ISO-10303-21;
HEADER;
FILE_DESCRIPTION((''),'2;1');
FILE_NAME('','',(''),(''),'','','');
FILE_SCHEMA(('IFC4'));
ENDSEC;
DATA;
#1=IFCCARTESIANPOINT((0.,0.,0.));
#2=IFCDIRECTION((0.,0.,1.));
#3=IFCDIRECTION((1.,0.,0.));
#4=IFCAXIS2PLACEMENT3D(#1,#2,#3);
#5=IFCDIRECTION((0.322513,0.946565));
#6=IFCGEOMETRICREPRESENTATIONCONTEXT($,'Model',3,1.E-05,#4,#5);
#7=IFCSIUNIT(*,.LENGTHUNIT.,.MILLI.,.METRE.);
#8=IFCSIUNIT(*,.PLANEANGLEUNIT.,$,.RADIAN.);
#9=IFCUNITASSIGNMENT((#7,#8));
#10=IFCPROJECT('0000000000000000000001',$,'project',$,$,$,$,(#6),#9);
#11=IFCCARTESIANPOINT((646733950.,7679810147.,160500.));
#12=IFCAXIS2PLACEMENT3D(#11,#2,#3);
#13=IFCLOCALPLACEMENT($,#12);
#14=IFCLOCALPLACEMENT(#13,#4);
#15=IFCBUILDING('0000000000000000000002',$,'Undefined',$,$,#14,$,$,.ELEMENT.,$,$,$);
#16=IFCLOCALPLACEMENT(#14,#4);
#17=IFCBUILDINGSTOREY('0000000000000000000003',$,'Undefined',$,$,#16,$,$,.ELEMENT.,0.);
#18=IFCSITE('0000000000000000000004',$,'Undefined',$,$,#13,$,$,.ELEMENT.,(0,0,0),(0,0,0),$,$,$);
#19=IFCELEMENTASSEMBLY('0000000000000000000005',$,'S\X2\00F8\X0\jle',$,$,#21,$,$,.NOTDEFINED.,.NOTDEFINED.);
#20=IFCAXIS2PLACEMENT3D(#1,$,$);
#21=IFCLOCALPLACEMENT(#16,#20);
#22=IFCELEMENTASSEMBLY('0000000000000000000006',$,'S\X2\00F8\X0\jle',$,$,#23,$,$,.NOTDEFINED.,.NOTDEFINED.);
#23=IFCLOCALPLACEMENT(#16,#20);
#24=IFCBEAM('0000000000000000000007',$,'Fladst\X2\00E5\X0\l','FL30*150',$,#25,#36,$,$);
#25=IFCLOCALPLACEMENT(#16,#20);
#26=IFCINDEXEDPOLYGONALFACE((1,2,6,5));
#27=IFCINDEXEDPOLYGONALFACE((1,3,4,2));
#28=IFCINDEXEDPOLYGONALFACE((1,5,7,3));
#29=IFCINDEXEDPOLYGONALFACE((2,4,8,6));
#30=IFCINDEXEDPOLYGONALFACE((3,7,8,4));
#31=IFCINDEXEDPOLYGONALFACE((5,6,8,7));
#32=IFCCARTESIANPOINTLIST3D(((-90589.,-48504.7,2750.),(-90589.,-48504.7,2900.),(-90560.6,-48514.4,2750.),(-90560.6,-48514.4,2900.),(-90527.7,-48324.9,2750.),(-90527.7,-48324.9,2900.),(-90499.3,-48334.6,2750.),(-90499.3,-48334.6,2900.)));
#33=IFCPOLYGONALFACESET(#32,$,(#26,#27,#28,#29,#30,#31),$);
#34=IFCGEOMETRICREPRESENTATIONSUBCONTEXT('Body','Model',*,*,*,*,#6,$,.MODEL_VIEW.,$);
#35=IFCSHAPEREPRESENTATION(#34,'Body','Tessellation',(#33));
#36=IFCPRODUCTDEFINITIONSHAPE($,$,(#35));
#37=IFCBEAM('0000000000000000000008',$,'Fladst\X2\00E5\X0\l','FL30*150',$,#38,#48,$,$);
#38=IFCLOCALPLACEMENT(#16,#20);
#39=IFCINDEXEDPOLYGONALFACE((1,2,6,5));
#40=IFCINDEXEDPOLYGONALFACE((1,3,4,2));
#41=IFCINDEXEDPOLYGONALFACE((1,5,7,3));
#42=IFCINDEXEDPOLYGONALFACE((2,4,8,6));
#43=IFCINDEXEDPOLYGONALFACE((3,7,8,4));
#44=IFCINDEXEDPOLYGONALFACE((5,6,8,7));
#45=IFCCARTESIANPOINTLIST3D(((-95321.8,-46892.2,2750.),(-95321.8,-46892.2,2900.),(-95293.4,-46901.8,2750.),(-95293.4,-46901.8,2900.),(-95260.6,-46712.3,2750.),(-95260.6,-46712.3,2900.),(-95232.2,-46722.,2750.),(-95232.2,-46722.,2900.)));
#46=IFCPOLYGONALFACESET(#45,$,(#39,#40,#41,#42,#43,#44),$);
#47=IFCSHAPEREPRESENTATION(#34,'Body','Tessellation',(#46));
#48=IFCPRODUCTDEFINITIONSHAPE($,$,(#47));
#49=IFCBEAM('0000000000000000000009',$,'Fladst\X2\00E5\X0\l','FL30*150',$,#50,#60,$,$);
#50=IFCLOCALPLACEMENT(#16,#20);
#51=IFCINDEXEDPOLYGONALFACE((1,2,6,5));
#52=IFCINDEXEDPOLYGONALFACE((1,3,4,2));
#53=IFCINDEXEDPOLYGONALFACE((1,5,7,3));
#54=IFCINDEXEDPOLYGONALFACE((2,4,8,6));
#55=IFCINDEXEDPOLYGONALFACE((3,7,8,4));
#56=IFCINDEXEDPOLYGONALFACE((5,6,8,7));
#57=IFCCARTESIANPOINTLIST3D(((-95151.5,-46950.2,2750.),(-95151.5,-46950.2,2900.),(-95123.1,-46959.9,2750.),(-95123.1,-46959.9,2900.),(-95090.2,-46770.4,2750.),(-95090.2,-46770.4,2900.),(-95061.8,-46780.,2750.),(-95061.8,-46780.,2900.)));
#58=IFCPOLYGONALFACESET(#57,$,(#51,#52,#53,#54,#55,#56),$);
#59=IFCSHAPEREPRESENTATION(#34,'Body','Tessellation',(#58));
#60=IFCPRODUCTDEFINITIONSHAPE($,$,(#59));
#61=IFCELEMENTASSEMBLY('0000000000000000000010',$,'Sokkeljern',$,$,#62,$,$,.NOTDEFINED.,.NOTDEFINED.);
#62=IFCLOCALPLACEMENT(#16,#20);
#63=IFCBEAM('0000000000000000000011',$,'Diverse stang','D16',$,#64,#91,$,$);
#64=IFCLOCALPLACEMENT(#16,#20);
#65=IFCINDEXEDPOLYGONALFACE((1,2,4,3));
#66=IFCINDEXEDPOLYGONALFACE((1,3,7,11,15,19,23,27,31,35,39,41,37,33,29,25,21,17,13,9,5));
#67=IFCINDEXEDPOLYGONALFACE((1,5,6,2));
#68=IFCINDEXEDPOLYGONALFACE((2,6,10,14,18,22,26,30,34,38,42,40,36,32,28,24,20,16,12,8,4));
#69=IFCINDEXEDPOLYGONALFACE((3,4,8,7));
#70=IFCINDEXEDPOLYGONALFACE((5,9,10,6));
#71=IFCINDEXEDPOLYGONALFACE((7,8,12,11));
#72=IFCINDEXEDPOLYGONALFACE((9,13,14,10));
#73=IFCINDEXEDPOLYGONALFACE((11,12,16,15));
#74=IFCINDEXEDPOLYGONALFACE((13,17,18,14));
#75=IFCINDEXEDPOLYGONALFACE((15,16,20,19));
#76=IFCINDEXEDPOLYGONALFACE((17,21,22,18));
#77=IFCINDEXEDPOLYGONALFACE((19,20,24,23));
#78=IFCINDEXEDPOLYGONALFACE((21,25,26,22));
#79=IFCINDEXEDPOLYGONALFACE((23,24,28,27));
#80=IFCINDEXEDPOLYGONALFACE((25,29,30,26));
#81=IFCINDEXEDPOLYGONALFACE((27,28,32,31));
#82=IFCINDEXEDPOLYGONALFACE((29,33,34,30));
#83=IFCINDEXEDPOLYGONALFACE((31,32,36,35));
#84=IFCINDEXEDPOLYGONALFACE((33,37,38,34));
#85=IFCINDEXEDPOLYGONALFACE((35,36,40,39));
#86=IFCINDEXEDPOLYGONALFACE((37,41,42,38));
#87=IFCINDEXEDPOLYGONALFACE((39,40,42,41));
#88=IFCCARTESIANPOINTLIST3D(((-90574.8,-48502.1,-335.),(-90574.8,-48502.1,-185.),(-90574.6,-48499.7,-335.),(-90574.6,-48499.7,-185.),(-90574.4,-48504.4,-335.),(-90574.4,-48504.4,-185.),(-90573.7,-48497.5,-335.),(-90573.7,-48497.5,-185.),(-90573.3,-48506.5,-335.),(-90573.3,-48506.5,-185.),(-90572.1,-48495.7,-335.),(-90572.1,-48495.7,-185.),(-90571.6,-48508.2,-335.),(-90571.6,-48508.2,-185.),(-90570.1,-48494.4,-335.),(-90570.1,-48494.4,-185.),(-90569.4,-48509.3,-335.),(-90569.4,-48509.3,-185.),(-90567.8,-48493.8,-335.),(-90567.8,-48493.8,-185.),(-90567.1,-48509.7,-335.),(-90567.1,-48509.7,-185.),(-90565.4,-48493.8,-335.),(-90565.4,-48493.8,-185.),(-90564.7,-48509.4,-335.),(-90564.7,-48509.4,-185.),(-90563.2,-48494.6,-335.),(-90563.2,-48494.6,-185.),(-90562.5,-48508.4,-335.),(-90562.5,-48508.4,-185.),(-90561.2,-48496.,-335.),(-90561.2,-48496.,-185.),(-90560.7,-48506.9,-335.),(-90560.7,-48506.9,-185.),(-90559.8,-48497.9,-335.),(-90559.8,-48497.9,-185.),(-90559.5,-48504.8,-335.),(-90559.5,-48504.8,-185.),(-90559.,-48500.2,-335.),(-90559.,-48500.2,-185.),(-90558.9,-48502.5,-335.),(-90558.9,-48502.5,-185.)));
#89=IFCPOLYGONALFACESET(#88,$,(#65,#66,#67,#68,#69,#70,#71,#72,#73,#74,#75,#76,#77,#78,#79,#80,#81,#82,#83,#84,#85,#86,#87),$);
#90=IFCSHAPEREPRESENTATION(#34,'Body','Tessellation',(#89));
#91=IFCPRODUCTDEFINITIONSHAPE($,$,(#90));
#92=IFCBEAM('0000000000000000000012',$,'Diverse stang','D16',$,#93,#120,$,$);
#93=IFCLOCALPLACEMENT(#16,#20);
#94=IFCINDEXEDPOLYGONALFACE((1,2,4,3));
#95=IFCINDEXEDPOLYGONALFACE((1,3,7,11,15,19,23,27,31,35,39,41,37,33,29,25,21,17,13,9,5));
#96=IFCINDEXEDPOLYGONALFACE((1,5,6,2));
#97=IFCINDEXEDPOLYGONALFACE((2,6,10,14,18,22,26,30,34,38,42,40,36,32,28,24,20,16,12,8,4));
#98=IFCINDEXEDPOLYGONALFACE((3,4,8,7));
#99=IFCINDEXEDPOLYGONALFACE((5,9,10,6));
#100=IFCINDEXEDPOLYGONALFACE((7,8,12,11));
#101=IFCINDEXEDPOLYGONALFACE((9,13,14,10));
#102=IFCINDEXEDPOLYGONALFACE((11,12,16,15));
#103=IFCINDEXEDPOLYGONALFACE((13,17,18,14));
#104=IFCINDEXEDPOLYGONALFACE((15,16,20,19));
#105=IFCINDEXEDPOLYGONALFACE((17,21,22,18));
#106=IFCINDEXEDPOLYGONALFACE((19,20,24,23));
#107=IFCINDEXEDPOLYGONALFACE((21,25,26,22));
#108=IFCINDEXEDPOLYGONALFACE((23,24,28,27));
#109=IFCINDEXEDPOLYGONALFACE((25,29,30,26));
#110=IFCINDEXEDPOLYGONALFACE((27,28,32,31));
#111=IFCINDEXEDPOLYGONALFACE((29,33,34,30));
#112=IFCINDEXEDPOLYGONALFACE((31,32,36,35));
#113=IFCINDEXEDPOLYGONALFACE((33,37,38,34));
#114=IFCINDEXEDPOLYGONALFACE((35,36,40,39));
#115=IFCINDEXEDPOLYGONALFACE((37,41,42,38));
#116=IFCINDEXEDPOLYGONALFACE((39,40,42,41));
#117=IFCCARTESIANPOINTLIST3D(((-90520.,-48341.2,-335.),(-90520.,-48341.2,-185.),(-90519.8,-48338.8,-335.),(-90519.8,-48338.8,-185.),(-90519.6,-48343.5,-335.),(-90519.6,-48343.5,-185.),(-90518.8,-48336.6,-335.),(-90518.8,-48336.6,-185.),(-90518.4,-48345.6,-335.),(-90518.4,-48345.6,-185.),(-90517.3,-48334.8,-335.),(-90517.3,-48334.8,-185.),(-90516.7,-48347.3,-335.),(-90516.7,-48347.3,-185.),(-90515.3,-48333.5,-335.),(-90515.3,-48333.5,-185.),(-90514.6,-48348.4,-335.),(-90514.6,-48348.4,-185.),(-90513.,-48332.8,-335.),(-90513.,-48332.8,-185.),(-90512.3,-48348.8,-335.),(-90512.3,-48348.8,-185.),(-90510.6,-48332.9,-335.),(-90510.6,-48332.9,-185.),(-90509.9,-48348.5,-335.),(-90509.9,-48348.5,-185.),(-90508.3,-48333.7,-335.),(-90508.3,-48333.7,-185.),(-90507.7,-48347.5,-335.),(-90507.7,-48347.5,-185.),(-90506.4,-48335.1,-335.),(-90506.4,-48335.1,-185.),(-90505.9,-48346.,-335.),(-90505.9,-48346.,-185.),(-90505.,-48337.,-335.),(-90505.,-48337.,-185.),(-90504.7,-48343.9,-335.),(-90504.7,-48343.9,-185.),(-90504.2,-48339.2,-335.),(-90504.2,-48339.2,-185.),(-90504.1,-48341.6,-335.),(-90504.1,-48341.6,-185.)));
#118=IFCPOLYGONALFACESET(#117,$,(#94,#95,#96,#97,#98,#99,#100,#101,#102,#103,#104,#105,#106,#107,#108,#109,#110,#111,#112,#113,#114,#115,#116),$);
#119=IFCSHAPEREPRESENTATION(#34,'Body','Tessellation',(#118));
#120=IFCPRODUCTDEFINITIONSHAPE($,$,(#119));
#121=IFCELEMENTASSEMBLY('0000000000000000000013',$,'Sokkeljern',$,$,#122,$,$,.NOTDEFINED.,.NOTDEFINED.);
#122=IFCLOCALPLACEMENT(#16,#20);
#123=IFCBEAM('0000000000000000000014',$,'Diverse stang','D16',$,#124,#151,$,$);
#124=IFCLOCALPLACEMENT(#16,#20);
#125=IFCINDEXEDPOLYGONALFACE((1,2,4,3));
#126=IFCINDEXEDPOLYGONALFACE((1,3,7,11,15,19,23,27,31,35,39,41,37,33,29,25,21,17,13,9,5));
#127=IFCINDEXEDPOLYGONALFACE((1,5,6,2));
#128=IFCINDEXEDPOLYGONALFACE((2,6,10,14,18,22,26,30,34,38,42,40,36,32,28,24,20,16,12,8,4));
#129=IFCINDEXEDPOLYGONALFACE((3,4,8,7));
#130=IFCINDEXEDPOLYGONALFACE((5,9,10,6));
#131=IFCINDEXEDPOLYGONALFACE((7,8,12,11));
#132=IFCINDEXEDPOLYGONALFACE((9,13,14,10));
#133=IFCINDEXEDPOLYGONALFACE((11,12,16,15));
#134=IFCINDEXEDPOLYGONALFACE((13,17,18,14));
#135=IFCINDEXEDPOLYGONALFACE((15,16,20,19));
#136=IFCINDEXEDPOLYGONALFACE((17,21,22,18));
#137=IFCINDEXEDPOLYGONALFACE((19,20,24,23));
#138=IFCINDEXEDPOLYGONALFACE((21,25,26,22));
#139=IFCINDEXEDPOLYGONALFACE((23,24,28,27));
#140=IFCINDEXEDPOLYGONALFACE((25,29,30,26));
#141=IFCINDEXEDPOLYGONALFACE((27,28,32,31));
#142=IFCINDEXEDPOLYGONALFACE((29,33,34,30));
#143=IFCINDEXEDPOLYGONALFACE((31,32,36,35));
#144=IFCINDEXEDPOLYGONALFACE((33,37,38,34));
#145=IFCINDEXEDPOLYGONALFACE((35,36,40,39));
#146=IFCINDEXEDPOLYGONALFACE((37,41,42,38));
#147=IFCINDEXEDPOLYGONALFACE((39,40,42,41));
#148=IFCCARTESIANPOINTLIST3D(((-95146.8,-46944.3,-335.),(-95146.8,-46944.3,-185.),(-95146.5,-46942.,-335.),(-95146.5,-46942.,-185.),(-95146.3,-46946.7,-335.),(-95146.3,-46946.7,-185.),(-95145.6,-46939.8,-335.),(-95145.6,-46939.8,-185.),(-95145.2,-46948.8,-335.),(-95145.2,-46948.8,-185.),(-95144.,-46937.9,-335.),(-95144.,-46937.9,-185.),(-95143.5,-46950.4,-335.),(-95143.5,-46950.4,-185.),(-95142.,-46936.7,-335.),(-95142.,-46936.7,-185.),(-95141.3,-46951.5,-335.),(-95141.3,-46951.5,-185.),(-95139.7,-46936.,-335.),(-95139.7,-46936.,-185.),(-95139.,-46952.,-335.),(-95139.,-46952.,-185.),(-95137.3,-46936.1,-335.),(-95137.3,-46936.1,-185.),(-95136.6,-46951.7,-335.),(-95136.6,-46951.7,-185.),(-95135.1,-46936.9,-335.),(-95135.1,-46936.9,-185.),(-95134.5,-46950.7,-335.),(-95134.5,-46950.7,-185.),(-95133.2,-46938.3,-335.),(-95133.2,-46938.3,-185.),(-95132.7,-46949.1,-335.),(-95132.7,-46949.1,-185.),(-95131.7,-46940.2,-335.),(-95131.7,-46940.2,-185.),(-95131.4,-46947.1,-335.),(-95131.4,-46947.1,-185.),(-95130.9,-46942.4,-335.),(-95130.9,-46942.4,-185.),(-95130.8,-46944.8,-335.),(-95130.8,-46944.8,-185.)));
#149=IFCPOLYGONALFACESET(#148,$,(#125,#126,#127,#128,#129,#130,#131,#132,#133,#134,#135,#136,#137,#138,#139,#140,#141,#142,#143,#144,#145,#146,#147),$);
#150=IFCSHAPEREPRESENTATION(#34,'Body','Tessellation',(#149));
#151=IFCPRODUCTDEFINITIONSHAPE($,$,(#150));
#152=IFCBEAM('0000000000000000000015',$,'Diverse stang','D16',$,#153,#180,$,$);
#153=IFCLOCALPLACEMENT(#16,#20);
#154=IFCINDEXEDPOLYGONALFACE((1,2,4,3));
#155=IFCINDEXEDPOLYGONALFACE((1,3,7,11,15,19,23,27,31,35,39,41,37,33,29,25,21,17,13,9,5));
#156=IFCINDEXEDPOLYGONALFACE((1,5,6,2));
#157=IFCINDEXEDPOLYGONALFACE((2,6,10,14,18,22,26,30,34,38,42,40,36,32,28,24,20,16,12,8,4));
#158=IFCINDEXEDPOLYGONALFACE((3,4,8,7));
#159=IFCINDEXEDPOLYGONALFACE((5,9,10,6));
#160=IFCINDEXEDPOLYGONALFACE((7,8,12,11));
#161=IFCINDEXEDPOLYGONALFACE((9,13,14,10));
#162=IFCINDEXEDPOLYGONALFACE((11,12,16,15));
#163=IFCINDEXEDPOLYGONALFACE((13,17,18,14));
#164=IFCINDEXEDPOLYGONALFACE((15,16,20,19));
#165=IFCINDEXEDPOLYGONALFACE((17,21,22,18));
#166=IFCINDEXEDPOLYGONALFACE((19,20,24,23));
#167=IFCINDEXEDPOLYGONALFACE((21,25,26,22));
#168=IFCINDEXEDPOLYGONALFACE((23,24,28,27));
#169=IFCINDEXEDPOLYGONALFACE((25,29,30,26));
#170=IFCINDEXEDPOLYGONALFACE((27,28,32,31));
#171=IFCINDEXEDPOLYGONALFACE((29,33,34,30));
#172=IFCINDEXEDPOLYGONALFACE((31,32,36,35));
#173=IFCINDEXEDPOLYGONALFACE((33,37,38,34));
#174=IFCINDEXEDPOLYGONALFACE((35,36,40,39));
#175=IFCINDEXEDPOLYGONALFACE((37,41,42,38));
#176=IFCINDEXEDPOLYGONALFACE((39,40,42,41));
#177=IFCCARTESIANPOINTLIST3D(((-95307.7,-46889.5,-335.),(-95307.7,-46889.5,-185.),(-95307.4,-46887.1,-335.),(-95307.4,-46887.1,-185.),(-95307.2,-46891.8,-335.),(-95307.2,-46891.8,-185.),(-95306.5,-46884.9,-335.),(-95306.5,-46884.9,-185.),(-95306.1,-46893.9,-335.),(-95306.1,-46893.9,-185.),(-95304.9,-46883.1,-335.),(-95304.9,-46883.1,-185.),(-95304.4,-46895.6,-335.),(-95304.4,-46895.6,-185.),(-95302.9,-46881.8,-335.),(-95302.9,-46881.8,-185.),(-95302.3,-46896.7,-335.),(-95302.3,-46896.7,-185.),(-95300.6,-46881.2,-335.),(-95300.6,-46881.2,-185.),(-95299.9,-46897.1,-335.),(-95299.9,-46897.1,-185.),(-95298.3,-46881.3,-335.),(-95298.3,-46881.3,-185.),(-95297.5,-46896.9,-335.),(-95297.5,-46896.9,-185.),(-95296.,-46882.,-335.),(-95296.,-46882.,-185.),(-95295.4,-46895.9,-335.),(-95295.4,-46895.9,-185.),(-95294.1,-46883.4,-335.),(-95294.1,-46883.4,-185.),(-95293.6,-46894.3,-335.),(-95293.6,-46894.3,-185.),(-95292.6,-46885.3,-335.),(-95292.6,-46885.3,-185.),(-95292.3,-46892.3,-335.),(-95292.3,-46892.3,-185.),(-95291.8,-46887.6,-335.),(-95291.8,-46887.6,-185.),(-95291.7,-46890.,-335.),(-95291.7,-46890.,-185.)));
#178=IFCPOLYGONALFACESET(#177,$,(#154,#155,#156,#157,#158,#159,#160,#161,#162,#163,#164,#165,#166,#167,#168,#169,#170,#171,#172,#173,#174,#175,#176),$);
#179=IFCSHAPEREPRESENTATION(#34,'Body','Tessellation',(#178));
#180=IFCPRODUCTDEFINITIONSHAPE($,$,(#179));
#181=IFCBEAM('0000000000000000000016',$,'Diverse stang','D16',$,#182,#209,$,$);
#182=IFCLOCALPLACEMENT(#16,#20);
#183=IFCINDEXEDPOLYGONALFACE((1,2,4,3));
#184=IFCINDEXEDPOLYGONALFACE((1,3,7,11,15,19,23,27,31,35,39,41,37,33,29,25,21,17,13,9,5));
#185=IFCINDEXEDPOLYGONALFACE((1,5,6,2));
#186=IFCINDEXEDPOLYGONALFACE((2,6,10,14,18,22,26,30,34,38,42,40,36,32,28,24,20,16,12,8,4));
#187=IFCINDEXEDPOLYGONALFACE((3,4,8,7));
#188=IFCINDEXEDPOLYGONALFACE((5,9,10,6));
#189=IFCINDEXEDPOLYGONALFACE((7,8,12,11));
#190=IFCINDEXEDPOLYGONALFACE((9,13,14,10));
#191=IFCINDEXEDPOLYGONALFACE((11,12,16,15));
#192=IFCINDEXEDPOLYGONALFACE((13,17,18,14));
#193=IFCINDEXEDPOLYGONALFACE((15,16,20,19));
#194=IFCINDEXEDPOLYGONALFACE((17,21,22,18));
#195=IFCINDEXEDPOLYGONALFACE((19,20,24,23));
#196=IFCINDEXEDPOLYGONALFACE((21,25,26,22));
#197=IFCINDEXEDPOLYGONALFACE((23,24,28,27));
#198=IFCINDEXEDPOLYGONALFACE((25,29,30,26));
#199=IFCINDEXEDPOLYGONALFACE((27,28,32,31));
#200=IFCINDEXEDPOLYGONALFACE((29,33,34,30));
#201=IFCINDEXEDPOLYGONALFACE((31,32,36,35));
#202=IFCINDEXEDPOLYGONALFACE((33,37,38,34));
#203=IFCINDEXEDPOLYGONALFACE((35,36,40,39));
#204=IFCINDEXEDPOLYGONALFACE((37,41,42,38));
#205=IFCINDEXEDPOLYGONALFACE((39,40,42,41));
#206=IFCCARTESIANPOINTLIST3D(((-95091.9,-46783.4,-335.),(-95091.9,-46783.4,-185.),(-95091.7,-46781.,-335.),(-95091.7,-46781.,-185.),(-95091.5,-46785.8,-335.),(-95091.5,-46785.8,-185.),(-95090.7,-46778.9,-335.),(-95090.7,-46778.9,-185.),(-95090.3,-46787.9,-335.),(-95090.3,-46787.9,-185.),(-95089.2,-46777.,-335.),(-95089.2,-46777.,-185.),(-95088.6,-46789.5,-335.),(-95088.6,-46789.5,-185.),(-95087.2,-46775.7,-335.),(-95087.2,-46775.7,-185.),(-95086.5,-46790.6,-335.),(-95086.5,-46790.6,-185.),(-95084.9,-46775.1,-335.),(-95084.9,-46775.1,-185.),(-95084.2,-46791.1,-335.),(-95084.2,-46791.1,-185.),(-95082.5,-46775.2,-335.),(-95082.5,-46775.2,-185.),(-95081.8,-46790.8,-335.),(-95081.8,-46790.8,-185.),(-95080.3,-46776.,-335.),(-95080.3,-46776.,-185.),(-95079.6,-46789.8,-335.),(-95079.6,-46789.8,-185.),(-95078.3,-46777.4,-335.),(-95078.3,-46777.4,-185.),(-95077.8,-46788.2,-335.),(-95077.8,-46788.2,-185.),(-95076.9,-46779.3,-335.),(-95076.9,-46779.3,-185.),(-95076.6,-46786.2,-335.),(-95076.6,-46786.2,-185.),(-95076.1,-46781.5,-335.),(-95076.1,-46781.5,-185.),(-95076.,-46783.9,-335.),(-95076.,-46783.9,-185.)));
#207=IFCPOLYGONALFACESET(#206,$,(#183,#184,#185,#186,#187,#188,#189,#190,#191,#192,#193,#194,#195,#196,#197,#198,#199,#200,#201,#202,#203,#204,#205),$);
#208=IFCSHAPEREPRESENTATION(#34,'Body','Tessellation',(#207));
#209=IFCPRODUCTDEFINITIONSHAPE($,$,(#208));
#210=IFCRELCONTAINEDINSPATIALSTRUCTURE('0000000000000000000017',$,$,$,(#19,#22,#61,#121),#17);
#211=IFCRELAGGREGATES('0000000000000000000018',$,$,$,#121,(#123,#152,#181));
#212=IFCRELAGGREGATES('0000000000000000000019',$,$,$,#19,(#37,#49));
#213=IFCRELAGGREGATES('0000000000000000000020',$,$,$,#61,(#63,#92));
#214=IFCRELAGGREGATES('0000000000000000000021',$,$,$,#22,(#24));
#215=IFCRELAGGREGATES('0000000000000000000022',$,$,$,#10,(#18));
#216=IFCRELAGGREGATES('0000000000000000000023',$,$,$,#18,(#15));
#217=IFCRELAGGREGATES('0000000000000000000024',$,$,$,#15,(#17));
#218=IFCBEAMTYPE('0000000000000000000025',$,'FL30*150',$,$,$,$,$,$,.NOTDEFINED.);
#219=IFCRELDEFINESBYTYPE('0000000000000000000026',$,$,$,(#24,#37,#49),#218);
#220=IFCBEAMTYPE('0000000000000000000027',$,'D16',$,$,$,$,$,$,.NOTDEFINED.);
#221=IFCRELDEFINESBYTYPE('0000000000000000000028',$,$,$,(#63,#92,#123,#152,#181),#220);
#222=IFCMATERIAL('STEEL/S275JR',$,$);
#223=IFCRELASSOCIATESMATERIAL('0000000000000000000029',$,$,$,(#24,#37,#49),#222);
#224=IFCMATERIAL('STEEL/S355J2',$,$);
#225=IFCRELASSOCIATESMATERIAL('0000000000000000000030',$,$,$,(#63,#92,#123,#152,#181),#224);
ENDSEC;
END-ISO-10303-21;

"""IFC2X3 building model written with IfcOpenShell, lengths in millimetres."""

from ifc_helpers import new_model, si_unit, direction, frame, origin_with_axes, origin_2d_with_axis, place, context, subcontext, project, spatial, rectangle, circle, extrude, material, type_object, element, aggregate, save


model = new_model("IFC2X3")

# Units and contexts
model_context = context("Model", 3, precision=1e-05, world=origin_with_axes(), true_north=direction((0.322513, 0.946565)))
body_context = subcontext(model_context, "Body", "Model", "MODEL_VIEW")
ifc_project = project(units=[si_unit("LENGTHUNIT", "METRE", prefix="MILLI"), si_unit("PLANEANGLEUNIT", "RADIAN")], contexts=[model_context])

# Site, building, storey
site_placement = place(None, frame((646733950.0, 7679810147.0, 160500.0), z_axis=(0.0, 0.0, 1.0), x_axis=(1.0, 0.0, 0.0)))
site = spatial("IfcSite", under=ifc_project, at=site_placement, Name="Undefined", CompositionType="ELEMENT", RefLatitude=(0, 0, 0), RefLongitude=(0, 0, 0))
building_placement = place(site_placement, origin_with_axes())
building = spatial("IfcBuilding", under=site, at=building_placement, Name="Undefined", CompositionType="ELEMENT")
storey_placement = place(building_placement, origin_with_axes())
storey = spatial("IfcBuildingStorey", under=building, at=storey_placement, Name="Undefined", CompositionType="ELEMENT", Elevation=0.0)

# Element assembly
assembly_1_placement = place(storey_placement, origin_with_axes())
assembly_1 = element("IfcElementAssembly", 1, at=assembly_1_placement, inside=storey, Name="Søjle", AssemblyPlace="NOTDEFINED", PredefinedType="NOTDEFINED")

# Element assembly, beam
assembly_2_placement = place(storey_placement, origin_with_axes())
assembly_2 = element("IfcElementAssembly", 2, at=assembly_2_placement, inside=storey, Name="Søjle", AssemblyPlace="NOTDEFINED", PredefinedType="NOTDEFINED")
ifc_material_1 = material(Name="STEEL/S275JR")
beam_type_1 = type_object("IfcBeamType", Name="FL30*150", PredefinedType="NOTDEFINED")
beam_1_placement = place(assembly_2_placement, frame((-90544.2, -48419.6, 2900.0), z_axis=(-0.322513, -0.946565, 0.0), x_axis=(0.0, 0.0, -1.0)))
beam_1 = element("IfcBeam", 3, at=beam_1_placement, type_object=beam_type_1, material=ifc_material_1, Name="Fladstål", Description="FL30*150", context=body_context, shape_type="SweptSolid", body=[
    extrude(rectangle(XDim=30.0, YDim=190.0, at=origin_2d_with_axis()), frame((150.0, 0.0, 0.0), z_axis=(-1.0, 0.0, 0.0), x_axis=(0.0, -1.0, 0.0)), (0.0, 0.0, 1.0), 150.0),
])

# Beams
beam_2_placement = place(assembly_1_placement, frame((-95277.0, -46807.1, 2900.0), z_axis=(-0.322513, -0.946565, 0.0), x_axis=(0.0, 0.0, -1.0)))
beam_2 = element("IfcBeam", 4, at=beam_2_placement, type_object=beam_type_1, material=ifc_material_1, Name="Fladstål", Description="FL30*150", context=body_context, shape_type="SweptSolid", body=[
    extrude(rectangle(XDim=30.0, YDim=190.0, at=origin_2d_with_axis()), frame((150.0, 0.0, 0.0), z_axis=(-1.0, 0.0, 0.0), x_axis=(0.0, -1.0, 0.0)), (0.0, 0.0, 1.0), 150.0),
])
beam_3_placement = place(assembly_1_placement, frame((-95106.6, -46865.1, 2900.0), z_axis=(-0.322513, -0.946565, 0.0), x_axis=(0.0, 0.0, -1.0)))
beam_3 = element("IfcBeam", 5, at=beam_3_placement, type_object=beam_type_1, material=ifc_material_1, Name="Fladstål", Description="FL30*150", context=body_context, shape_type="SweptSolid", body=[
    extrude(rectangle(XDim=30.0, YDim=190.0, at=origin_2d_with_axis()), frame((150.0, 0.0, 0.0), z_axis=(-1.0, 0.0, 0.0), x_axis=(0.0, -1.0, 0.0)), (0.0, 0.0, 1.0), 150.0),
])

# Element assemblies, beams
assembly_3_placement = place(storey_placement, origin_with_axes())
assembly_3 = element("IfcElementAssembly", 6, at=assembly_3_placement, inside=storey, Name="Sokkeljern", AssemblyPlace="NOTDEFINED", PredefinedType="NOTDEFINED")
ifc_material_2 = material(Name="STEEL/S355J2")
beam_type_2 = type_object("IfcBeamType", Name="D16", PredefinedType="NOTDEFINED")
beam_4_placement = place(assembly_3_placement, frame((-90566.9, -48501.7, -185.0), z_axis=(0.946565, -0.322513, 0.0), x_axis=(0.0, 0.0, -1.0)))
beam_4 = element("IfcBeam", 7, at=beam_4_placement, type_object=beam_type_2, material=ifc_material_2, Name="Diverse stang", Description="D16", context=body_context, shape_type="SweptSolid", body=[
    extrude(circle(Radius=8.0, at=origin_2d_with_axis()), frame((150.0, 0.0, 0.0), z_axis=(-1.0, 0.0, 0.0), x_axis=(0.0, -1.0, 0.0)), (0.0, 0.0, 1.0), 150.0),
])
beam_5_placement = place(assembly_3_placement, frame((-90512.0, -48340.8, -185.0), z_axis=(0.946565, -0.322513, 0.0), x_axis=(0.0, 0.0, -1.0)))
beam_5 = element("IfcBeam", 8, at=beam_5_placement, type_object=beam_type_2, material=ifc_material_2, Name="Diverse stang", Description="D16", context=body_context, shape_type="SweptSolid", body=[
    extrude(circle(Radius=8.0, at=origin_2d_with_axis()), frame((150.0, 0.0, 0.0), z_axis=(-1.0, 0.0, 0.0), x_axis=(0.0, -1.0, 0.0)), (0.0, 0.0, 1.0), 150.0),
])
assembly_4_placement = place(storey_placement, origin_with_axes())
assembly_4 = element("IfcElementAssembly", 9, at=assembly_4_placement, inside=storey, Name="Sokkeljern", AssemblyPlace="NOTDEFINED", PredefinedType="NOTDEFINED")
beam_6_placement = place(assembly_4_placement, frame((-95138.8, -46944.0, -185.0), z_axis=(0.946565, -0.322513, 0.0), x_axis=(0.0, 0.0, -1.0)))
beam_6 = element("IfcBeam", 10, at=beam_6_placement, type_object=beam_type_2, material=ifc_material_2, Name="Diverse stang", Description="D16", context=body_context, shape_type="SweptSolid", body=[
    extrude(circle(Radius=8.0, at=origin_2d_with_axis()), frame((150.0, 0.0, 0.0), z_axis=(-1.0, 0.0, 0.0), x_axis=(0.0, -1.0, 0.0)), (0.0, 0.0, 1.0), 150.0),
])
beam_7_placement = place(assembly_4_placement, frame((-95299.7, -46889.1, -185.0), z_axis=(0.946565, -0.322513, 0.0), x_axis=(0.0, 0.0, -1.0)))
beam_7 = element("IfcBeam", 11, at=beam_7_placement, type_object=beam_type_2, material=ifc_material_2, Name="Diverse stang", Description="D16", context=body_context, shape_type="SweptSolid", body=[
    extrude(circle(Radius=8.0, at=origin_2d_with_axis()), frame((150.0, 0.0, 0.0), z_axis=(-1.0, 0.0, 0.0), x_axis=(0.0, -1.0, 0.0)), (0.0, 0.0, 1.0), 150.0),
])
beam_8_placement = place(assembly_4_placement, frame((-95083.9, -46783.1, -185.0), z_axis=(0.946565, -0.322513, 0.0), x_axis=(0.0, 0.0, -1.0)))
beam_8 = element("IfcBeam", 12, at=beam_8_placement, type_object=beam_type_2, material=ifc_material_2, Name="Diverse stang", Description="D16", context=body_context, shape_type="SweptSolid", body=[
    extrude(circle(Radius=8.0, at=origin_2d_with_axis()), frame((150.0, 0.0, 0.0), z_axis=(-1.0, 0.0, 0.0), x_axis=(0.0, -1.0, 0.0)), (0.0, 0.0, 1.0), 150.0),
])
aggregate(assembly_4, [beam_6, beam_7, beam_8])

aggregate(assembly_1, [beam_2, beam_3])
aggregate(assembly_3, [beam_4, beam_5])

aggregate(assembly_2, [beam_1])

save(model, "model.ifc")
